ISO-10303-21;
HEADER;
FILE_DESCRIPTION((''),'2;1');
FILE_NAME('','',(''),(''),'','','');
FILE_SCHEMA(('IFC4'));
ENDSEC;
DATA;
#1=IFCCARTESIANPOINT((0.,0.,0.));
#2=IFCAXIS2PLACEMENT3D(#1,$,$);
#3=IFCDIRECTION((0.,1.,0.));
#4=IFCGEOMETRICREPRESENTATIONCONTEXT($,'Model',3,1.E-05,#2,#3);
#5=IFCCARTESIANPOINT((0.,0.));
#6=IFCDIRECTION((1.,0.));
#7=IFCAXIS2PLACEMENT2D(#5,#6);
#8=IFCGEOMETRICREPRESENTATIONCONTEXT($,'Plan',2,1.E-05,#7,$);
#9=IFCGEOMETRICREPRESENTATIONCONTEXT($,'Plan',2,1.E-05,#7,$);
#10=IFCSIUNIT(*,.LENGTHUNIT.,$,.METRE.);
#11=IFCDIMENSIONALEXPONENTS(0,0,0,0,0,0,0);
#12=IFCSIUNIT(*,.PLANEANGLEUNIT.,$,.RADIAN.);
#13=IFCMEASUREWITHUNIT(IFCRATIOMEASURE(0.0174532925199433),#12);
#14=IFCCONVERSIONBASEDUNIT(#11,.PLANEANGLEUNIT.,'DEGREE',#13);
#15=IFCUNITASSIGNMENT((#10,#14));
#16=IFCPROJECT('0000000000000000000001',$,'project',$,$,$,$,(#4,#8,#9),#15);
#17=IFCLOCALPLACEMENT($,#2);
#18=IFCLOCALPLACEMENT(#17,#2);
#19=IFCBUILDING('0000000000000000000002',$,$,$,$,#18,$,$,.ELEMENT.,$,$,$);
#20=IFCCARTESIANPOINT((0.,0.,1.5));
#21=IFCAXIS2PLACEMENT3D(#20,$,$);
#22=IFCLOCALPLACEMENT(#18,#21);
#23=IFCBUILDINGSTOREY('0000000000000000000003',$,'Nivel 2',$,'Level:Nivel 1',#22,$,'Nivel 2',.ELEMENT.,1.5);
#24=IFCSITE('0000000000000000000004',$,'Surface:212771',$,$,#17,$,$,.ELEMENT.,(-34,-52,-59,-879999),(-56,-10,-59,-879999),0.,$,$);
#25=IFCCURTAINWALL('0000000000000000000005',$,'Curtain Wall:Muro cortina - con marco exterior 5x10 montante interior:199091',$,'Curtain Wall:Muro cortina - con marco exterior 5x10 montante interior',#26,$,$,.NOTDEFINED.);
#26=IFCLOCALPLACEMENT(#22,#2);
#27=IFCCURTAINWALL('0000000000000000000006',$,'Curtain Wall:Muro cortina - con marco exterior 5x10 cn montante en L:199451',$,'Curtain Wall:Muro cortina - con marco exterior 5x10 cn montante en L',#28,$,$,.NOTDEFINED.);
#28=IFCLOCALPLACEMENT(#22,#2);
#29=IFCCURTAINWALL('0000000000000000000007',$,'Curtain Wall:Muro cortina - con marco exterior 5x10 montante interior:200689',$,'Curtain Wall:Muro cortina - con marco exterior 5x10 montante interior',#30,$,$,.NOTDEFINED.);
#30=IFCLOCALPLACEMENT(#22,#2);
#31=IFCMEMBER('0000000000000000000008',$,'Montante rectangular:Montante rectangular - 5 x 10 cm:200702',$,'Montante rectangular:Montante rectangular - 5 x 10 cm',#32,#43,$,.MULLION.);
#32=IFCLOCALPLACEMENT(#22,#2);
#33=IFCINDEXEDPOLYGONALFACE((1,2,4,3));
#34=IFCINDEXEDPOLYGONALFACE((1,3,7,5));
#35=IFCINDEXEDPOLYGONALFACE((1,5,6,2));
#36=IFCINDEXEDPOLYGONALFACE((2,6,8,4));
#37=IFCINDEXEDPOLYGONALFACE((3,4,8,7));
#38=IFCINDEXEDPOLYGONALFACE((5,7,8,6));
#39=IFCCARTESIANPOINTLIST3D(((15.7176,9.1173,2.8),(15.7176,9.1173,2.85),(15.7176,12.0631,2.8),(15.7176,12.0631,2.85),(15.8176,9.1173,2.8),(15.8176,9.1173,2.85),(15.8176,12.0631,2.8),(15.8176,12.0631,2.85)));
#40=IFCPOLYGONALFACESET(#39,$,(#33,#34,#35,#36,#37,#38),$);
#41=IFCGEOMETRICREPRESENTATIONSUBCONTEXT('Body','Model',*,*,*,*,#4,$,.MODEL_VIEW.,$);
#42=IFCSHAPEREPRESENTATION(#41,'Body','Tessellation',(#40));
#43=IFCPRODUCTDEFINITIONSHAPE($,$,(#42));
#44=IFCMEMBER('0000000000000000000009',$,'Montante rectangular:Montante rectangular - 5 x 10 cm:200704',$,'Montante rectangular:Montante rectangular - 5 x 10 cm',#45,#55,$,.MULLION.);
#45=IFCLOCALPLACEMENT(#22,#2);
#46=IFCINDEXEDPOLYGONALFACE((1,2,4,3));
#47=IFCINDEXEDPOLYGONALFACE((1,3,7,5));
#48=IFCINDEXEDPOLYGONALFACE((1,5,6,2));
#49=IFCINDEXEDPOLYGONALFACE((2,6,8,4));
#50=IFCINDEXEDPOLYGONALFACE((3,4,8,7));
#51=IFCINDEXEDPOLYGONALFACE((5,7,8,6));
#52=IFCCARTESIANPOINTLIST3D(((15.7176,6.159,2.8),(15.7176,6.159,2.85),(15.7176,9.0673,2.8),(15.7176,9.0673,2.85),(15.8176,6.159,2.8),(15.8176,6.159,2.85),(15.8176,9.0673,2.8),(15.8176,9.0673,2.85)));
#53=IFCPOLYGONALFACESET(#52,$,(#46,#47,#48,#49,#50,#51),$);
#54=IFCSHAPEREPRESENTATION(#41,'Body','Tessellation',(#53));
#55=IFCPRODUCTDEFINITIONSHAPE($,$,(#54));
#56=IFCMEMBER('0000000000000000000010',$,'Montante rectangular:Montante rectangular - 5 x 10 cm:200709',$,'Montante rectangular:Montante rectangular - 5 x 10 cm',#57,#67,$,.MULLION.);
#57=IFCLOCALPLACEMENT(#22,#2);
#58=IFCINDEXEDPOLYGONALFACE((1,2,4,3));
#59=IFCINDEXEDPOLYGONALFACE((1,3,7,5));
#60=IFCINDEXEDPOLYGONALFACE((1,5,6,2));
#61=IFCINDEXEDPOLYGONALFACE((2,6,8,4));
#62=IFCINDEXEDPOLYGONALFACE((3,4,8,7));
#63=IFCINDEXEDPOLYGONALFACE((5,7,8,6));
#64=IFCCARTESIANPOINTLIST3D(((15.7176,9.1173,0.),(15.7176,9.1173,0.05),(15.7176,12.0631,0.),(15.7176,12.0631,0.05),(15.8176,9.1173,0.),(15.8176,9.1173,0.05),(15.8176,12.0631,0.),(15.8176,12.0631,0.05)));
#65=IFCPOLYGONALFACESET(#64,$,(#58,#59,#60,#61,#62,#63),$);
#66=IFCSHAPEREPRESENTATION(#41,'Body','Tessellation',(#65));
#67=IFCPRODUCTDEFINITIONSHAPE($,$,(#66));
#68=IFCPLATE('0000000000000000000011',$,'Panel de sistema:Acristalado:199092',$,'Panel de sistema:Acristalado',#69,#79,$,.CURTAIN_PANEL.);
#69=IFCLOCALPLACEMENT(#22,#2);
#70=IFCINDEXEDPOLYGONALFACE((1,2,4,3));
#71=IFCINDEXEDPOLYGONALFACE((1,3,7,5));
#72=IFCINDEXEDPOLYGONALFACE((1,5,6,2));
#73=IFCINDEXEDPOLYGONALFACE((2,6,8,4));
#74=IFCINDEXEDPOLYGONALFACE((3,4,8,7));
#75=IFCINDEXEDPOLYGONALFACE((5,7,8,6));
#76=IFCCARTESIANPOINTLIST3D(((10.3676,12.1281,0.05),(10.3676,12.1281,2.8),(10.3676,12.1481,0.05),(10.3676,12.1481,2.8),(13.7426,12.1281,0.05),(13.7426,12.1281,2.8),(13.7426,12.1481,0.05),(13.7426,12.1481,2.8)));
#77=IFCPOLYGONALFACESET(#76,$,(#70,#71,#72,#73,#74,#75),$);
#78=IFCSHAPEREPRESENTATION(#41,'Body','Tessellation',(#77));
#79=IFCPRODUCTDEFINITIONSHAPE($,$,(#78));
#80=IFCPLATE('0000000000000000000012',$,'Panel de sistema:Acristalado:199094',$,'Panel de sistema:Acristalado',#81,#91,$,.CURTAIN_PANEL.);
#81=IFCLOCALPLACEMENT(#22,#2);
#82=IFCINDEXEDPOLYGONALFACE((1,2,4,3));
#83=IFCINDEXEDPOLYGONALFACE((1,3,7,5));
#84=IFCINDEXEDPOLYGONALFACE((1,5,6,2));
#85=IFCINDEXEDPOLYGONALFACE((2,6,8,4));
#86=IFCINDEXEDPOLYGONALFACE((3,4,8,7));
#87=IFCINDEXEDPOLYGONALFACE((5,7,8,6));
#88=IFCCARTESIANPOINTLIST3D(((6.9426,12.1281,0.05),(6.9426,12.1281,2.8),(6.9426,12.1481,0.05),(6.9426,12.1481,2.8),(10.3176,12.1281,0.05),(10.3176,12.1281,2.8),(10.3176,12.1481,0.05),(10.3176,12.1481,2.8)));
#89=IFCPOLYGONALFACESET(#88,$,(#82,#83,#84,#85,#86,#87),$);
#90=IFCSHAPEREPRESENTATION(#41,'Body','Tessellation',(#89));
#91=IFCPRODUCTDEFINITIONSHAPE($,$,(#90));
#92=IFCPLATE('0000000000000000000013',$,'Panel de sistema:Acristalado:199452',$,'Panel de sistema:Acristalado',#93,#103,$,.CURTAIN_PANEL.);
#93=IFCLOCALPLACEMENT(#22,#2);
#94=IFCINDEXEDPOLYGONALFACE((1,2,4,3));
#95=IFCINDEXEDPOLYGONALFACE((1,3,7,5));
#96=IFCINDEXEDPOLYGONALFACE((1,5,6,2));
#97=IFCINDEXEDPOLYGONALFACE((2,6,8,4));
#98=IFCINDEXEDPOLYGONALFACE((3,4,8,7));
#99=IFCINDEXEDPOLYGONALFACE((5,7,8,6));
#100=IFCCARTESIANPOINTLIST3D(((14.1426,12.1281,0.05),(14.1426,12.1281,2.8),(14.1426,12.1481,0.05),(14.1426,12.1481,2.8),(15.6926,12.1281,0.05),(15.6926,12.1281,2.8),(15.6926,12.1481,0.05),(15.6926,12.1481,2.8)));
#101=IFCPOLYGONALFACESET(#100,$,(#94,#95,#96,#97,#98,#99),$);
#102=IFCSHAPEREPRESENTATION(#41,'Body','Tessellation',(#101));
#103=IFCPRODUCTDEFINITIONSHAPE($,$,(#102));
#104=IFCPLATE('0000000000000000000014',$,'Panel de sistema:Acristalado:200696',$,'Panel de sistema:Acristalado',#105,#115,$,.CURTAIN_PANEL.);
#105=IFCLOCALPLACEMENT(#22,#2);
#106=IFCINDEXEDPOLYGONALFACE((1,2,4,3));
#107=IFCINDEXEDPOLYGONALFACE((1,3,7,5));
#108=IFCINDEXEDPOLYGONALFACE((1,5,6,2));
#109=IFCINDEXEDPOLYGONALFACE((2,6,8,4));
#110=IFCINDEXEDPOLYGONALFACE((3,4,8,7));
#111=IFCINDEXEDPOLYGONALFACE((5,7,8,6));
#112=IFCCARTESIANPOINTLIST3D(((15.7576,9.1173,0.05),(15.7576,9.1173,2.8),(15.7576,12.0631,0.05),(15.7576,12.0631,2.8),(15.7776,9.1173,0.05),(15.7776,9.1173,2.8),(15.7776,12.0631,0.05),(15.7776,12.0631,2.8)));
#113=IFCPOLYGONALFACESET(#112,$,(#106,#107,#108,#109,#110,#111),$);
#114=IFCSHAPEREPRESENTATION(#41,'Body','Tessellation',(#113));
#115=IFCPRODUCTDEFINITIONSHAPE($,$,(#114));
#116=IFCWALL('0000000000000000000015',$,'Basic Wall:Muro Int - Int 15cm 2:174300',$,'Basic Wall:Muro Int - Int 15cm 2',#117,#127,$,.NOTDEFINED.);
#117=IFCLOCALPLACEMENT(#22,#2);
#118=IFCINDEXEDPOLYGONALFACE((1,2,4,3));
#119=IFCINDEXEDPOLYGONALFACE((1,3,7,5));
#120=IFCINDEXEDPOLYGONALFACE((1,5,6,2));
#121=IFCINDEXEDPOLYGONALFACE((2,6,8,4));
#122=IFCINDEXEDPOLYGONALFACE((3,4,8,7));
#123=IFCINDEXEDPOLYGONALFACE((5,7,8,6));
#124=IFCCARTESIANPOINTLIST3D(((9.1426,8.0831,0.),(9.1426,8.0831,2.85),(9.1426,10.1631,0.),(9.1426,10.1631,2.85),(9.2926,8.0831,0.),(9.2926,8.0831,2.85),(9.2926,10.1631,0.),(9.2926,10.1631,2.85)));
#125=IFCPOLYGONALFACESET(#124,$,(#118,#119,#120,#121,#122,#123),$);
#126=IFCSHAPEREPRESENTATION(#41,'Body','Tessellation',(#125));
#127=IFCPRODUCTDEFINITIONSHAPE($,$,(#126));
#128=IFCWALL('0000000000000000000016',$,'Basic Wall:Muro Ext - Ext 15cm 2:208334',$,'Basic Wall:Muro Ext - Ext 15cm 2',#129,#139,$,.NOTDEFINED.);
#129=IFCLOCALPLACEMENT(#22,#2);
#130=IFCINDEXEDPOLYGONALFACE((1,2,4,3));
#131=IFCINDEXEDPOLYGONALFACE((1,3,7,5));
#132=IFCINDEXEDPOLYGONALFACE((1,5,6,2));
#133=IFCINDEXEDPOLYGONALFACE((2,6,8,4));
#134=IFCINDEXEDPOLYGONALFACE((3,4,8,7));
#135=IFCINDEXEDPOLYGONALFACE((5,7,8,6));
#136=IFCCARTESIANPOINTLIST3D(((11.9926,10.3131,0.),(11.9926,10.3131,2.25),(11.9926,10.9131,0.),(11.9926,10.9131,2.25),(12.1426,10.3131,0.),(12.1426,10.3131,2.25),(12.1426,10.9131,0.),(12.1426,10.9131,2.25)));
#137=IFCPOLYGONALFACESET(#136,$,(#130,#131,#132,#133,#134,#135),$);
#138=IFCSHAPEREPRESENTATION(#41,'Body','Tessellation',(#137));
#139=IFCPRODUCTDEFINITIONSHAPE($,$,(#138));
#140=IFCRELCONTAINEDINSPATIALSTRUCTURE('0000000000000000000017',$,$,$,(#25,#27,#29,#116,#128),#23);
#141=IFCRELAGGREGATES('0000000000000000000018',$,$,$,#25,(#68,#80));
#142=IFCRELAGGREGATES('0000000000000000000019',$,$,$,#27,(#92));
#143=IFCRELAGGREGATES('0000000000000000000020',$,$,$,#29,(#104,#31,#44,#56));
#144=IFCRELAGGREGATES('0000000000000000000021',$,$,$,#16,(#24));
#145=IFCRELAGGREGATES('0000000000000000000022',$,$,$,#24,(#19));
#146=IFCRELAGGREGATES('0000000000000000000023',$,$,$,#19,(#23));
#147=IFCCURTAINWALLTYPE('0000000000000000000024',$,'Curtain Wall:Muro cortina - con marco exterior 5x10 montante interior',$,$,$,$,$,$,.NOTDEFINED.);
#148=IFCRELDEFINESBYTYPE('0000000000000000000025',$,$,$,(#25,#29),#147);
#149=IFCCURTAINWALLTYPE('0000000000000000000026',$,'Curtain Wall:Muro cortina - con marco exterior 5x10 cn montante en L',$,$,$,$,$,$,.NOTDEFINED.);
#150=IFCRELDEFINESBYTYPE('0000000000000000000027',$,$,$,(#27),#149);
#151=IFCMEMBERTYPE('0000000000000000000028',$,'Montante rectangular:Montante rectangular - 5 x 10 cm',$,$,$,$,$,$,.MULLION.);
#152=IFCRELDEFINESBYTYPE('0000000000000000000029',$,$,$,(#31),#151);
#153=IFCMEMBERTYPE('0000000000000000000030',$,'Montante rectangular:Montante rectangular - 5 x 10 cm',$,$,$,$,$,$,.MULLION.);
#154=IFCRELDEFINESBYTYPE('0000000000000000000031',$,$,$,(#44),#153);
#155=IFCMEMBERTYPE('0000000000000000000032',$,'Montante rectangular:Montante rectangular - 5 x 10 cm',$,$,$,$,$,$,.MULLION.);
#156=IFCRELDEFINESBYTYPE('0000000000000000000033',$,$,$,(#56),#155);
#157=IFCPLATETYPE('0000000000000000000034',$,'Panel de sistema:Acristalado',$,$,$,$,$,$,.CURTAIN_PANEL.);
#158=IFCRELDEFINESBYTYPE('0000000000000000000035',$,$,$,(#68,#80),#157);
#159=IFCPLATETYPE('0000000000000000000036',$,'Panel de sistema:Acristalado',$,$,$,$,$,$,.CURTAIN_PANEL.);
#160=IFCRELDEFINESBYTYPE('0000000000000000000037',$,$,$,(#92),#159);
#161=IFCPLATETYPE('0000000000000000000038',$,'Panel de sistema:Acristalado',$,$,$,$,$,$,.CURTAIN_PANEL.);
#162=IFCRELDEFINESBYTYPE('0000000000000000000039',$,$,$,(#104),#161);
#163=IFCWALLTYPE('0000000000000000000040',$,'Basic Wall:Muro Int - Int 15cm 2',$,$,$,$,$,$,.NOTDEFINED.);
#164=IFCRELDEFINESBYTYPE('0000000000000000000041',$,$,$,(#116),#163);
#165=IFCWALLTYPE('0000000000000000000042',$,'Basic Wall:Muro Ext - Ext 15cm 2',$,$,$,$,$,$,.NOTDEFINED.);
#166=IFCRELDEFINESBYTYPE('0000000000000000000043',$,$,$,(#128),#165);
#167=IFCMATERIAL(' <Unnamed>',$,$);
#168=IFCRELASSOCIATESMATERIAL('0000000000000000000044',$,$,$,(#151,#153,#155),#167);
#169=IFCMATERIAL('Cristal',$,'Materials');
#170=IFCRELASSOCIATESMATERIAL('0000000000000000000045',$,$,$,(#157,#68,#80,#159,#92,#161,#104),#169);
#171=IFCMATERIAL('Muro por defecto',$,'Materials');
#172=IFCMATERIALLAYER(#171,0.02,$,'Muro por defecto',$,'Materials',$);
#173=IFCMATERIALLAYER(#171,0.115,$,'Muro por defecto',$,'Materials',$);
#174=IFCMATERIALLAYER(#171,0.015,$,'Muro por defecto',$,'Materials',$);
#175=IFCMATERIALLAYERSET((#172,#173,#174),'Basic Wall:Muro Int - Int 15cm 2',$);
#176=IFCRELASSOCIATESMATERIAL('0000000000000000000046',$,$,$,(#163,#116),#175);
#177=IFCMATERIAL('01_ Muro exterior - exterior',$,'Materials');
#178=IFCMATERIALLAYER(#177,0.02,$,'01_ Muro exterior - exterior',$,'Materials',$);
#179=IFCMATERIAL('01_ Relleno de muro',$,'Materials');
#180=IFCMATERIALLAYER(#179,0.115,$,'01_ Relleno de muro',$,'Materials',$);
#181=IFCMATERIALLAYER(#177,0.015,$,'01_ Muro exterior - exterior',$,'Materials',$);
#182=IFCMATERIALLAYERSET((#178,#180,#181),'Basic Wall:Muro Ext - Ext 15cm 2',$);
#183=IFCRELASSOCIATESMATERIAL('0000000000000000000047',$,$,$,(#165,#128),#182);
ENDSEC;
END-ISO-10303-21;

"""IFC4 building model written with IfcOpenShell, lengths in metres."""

from ifc_helpers import new_model, entity, si_unit, converted_unit, direction, frame, origin, origin_2d_with_axis, place, context, subcontext, project, spatial, indexed_curve, outline, extrude, shape, source, transform, mapped, material, layer, layer_set, type_object, type_shapes, element, aggregate, save


model = new_model("IFC4")

# Units and contexts
model_context = context("Model", 3, precision=1e-05, world=origin(), true_north=direction((0.0, 1.0, 0.0)))
plan_context_1 = context("Plan", 2, precision=1e-05, world=origin_2d_with_axis())
plan_context_2 = context("Plan", 2, precision=1e-05, world=origin_2d_with_axis())
body_context = subcontext(model_context, "Body", "Model", "MODEL_VIEW")
footprint_context = subcontext(model_context, "FootPrint", "Model", "MODEL_VIEW")
ifc_project = project(units=[si_unit("LENGTHUNIT", "METRE"), converted_unit("PLANEANGLEUNIT", "DEGREE", entity("IfcRatioMeasure", 0.0174532925199433), si_unit("PLANEANGLEUNIT", "RADIAN"), dimensions=[0, 0, 0, 0, 0, 0, 0])], contexts=[model_context, plan_context_1, plan_context_2])

# Site, building, storey
site_placement = place(None, origin())
site = spatial("IfcSite", under=ifc_project, at=site_placement, Name="Surface:212771", CompositionType="ELEMENT", RefLatitude=(-34, -52, -59, -879999), RefLongitude=(-56, -10, -59, -879999), RefElevation=0.0)
building_placement = place(site_placement, origin())
building = spatial("IfcBuilding", under=site, at=building_placement, CompositionType="ELEMENT")
storey_placement = place(building_placement, frame((0.0, 0.0, 1.5)))
storey = spatial("IfcBuildingStorey", under=building, at=storey_placement, Name="Nivel 2", ObjectType="Level:Nivel 1", LongName="Nivel 2", CompositionType="ELEMENT", Elevation=1.5)

# Curtain wall
curtain_wall_type_1 = type_object("IfcCurtainWallType", Name="Curtain Wall:Muro cortina - con marco exterior 5x10 montante interior", PredefinedType="NOTDEFINED")
curtain_wall_1_placement = place(storey_placement, frame((0.0, 0.0, -1.5)))
curtain_wall_1 = element("IfcCurtainWall", 1, at=curtain_wall_1_placement, inside=storey, type_object=curtain_wall_type_1, Name="Curtain Wall:Muro cortina - con marco exterior 5x10 montante interior:199091", ObjectType="Curtain Wall:Muro cortina - con marco exterior 5x10 montante interior", PredefinedType="NOTDEFINED")
ifc_material_1 = material(Name=" <Unnamed>")

# Curtain wall
curtain_wall_type_2 = type_object("IfcCurtainWallType", Name="Curtain Wall:Muro cortina - con marco exterior 5x10 cn montante en L", PredefinedType="NOTDEFINED")
curtain_wall_2_placement = place(storey_placement, frame((0.0, 0.0, -1.5)))
curtain_wall_2 = element("IfcCurtainWall", 2, at=curtain_wall_2_placement, inside=storey, type_object=curtain_wall_type_2, Name="Curtain Wall:Muro cortina - con marco exterior 5x10 cn montante en L:199451", ObjectType="Curtain Wall:Muro cortina - con marco exterior 5x10 cn montante en L", PredefinedType="NOTDEFINED")

# Curtain wall
curtain_wall_3_placement = place(storey_placement, frame((0.0, 0.0, -1.5)))
curtain_wall_3 = element("IfcCurtainWall", 3, at=curtain_wall_3_placement, inside=storey, type_object=curtain_wall_type_1, Name="Curtain Wall:Muro cortina - con marco exterior 5x10 montante interior:200689", ObjectType="Curtain Wall:Muro cortina - con marco exterior 5x10 montante interior", PredefinedType="NOTDEFINED")

# Members
member_type_1 = type_object("IfcMemberType", Name="Montante rectangular:Montante rectangular - 5 x 10 cm", PredefinedType="MULLION", material=ifc_material_1)
shared_shape_1 = source(origin(), body_context, "Body", "SweptSolid", [
    extrude(outline(indexed_curve([(-0.05, -0.025), (0.05, -0.025), (0.05, 0.025), (-0.05, 0.025), (-0.05, -0.025)], self_intersect=False)), frame((-0.025, 0.0, -2.9458), z_axis=(0.0, 0.0, 1.0), x_axis=(0.0, -1.0, 0.0)), (0.0, 0.0, 1.0), 2.9458),
])
type_shapes(member_type_1, [shared_shape_1])
member_1_placement = place(storey_placement, frame((15.7676, 12.0631, 2.85), z_axis=(0.0, 1.0, 0.0), x_axis=(0.0, 0.0, 1.0)))
member_1 = element("IfcMember", 4, at=member_1_placement, type_object=member_type_1, Name="Montante rectangular:Montante rectangular - 5 x 10 cm:200702", ObjectType="Montante rectangular:Montante rectangular - 5 x 10 cm", PredefinedType="MULLION", context=body_context, shape_type="MappedRepresentation", body=[
    mapped(shared_shape_1, transform((0.0, 0.0, 0.0), scale=1.0)),
])
member_type_2 = type_object("IfcMemberType", Name="Montante rectangular:Montante rectangular - 5 x 10 cm", PredefinedType="MULLION", material=ifc_material_1)
shared_shape_2 = source(origin(), body_context, "Body", "SweptSolid", [
    extrude(outline(indexed_curve([(-0.05, -0.025), (0.05, -0.025), (0.05, 0.025), (-0.05, 0.025), (-0.05, -0.025)], self_intersect=False)), frame((-0.025, 0.0, -2.9083), z_axis=(0.0, 0.0, 1.0), x_axis=(0.0, -1.0, 0.0)), (0.0, 0.0, 1.0), 2.9083),
])
type_shapes(member_type_2, [shared_shape_2])
member_2_placement = place(storey_placement, frame((15.7676, 9.0673, 2.85), z_axis=(0.0, 1.0, 0.0), x_axis=(0.0, 0.0, 1.0)))
member_2 = element("IfcMember", 5, at=member_2_placement, type_object=member_type_2, Name="Montante rectangular:Montante rectangular - 5 x 10 cm:200704", ObjectType="Montante rectangular:Montante rectangular - 5 x 10 cm", PredefinedType="MULLION", context=body_context, shape_type="MappedRepresentation", body=[
    mapped(shared_shape_2, transform((0.0, 0.0, 0.0), scale=1.0)),
])
member_type_3 = type_object("IfcMemberType", Name="Montante rectangular:Montante rectangular - 5 x 10 cm", PredefinedType="MULLION", material=ifc_material_1)
shared_shape_3 = source(origin(), body_context, "Body", "SweptSolid", [
    extrude(outline(indexed_curve([(-0.05, -0.025), (0.05, -0.025), (0.05, 0.025), (-0.05, 0.025), (-0.05, -0.025)], self_intersect=False)), frame((-0.025, 0.0, -2.9458), z_axis=(0.0, 0.0, 1.0), x_axis=(0.0, -1.0, 0.0)), (0.0, 0.0, 1.0), 2.9458),
])
type_shapes(member_type_3, [shared_shape_3])
member_3_placement = place(storey_placement, frame((15.7676, 9.1173, 0.0), z_axis=(0.0, -1.0, 0.0), x_axis=(0.0, 0.0, -1.0)))
member_3 = element("IfcMember", 6, at=member_3_placement, type_object=member_type_3, Name="Montante rectangular:Montante rectangular - 5 x 10 cm:200709", ObjectType="Montante rectangular:Montante rectangular - 5 x 10 cm", PredefinedType="MULLION", context=body_context, shape_type="MappedRepresentation", body=[
    mapped(shared_shape_3, transform((0.0, 0.0, 0.0), scale=1.0)),
])

# Plates
ifc_material_2 = material(Name="Cristal", Category="Materials")
plate_type_1 = type_object("IfcPlateType", Name="Panel de sistema:Acristalado", PredefinedType="CURTAIN_PANEL", material=ifc_material_2)
shared_shape_4 = source(origin(), body_context, "Body", "SweptSolid", [
    extrude(outline(indexed_curve([(-0.01, -1.6875), (0.01, -1.6875), (0.01, 1.6875), (-0.01, 1.6875), (-0.01, -1.6875)], self_intersect=False)), frame((0.0, 0.0, 0.0), z_axis=(0.0, 0.0, 1.0), x_axis=(0.0, 1.0, 0.0)), (0.0, 0.0, 1.0), 2.75),
])
shared_shape_5 = source(origin(), footprint_context, "FootPrint", "Curve2D", [
    entity("IfcIndexedPolyCurve", entity("IfcCartesianPointList2D", [[1.6875, -0.01], [1.6875, 0.01], [-1.6875, 0.01], [-1.6875, -0.01], [1.6875, -0.01]]), None, False),
])
type_shapes(plate_type_1, [shared_shape_4, shared_shape_5])
plate_1_placement = place(curtain_wall_1_placement, frame((12.0551, 12.1381, 1.55), z_axis=(0.0, 0.0, 1.0), x_axis=(-1.0, 0.0, 0.0)))
plate_1 = element("IfcPlate", 7, at=plate_1_placement, type_object=plate_type_1, material=ifc_material_2, Name="Panel de sistema:Acristalado:199092", ObjectType="Panel de sistema:Acristalado", PredefinedType="CURTAIN_PANEL", shapes=[
    shape(body_context, "Body", "MappedRepresentation", [mapped(shared_shape_4, transform((0.0, 0.0, 0.0), scale=1.0))]),
    shape(body_context, "Body", "MappedRepresentation", [mapped(shared_shape_5, transform((0.0, 0.0, 0.0), scale=1.0))]),
])
plate_2_placement = place(curtain_wall_1_placement, frame((8.6301, 12.1381, 1.55), z_axis=(0.0, 0.0, 1.0), x_axis=(-1.0, 0.0, 0.0)))
plate_2 = element("IfcPlate", 8, at=plate_2_placement, type_object=plate_type_1, material=ifc_material_2, Name="Panel de sistema:Acristalado:199094", ObjectType="Panel de sistema:Acristalado", PredefinedType="CURTAIN_PANEL", shapes=[
    shape(body_context, "Body", "MappedRepresentation", [mapped(shared_shape_4, transform((0.0, 0.0, 0.0), scale=1.0))]),
    shape(body_context, "Body", "MappedRepresentation", [mapped(shared_shape_5, transform((0.0, 0.0, 0.0), scale=1.0))]),
])
aggregate(curtain_wall_1, [plate_1, plate_2])
plate_type_2 = type_object("IfcPlateType", Name="Panel de sistema:Acristalado", PredefinedType="CURTAIN_PANEL", material=ifc_material_2)
shared_shape_6 = source(origin(), body_context, "Body", "SweptSolid", [
    extrude(outline(indexed_curve([(-0.01, -0.775), (0.01, -0.775), (0.01, 0.775), (-0.01, 0.775), (-0.01, -0.775)], self_intersect=False)), frame((0.0, 0.0, 0.0), z_axis=(0.0, 0.0, 1.0), x_axis=(0.0, 1.0, 0.0)), (0.0, 0.0, 1.0), 2.75),
])
shared_shape_7 = source(origin(), footprint_context, "FootPrint", "Curve2D", [
    entity("IfcIndexedPolyCurve", entity("IfcCartesianPointList2D", [[0.775, -0.01], [0.775, 0.01], [-0.775, 0.01], [-0.775, -0.01], [0.775, -0.01]]), None, False),
])
type_shapes(plate_type_2, [shared_shape_6, shared_shape_7])
plate_3_placement = place(curtain_wall_2_placement, frame((14.9176, 12.1381, 1.55)))
plate_3 = element("IfcPlate", 9, at=plate_3_placement, type_object=plate_type_2, material=ifc_material_2, Name="Panel de sistema:Acristalado:199452", ObjectType="Panel de sistema:Acristalado", PredefinedType="CURTAIN_PANEL", shapes=[
    shape(body_context, "Body", "MappedRepresentation", [mapped(shared_shape_6, transform((0.0, 0.0, 0.0), scale=1.0))]),
    shape(body_context, "Body", "MappedRepresentation", [mapped(shared_shape_7, transform((0.0, 0.0, 0.0), scale=1.0))]),
])
aggregate(curtain_wall_2, [plate_3])
plate_type_3 = type_object("IfcPlateType", Name="Panel de sistema:Acristalado", PredefinedType="CURTAIN_PANEL", material=ifc_material_2)
shared_shape_8 = source(origin(), body_context, "Body", "SweptSolid", [
    extrude(outline(indexed_curve([(-0.01, -1.4729), (0.01, -1.4729), (0.01, 1.4729), (-0.01, 1.4729), (-0.01, -1.4729)], self_intersect=False)), frame((0.0, 0.0, 0.0), z_axis=(0.0, 0.0, 1.0), x_axis=(0.0, 1.0, 0.0)), (0.0, 0.0, 1.0), 2.75),
])
shared_shape_9 = source(origin(), footprint_context, "FootPrint", "Curve2D", [
    entity("IfcIndexedPolyCurve", entity("IfcCartesianPointList2D", [[1.4729, -0.01], [1.4729, 0.01], [-1.4729, 0.01], [-1.4729, -0.01], [1.4729, -0.01]]), None, False),
])
type_shapes(plate_type_3, [shared_shape_8, shared_shape_9])
plate_4_placement = place(curtain_wall_3_placement, frame((15.7676, 10.5902, 1.55), z_axis=(0.0, 0.0, 1.0), x_axis=(0.0, 1.0, 0.0)))
plate_4 = element("IfcPlate", 10, at=plate_4_placement, type_object=plate_type_3, material=ifc_material_2, Name="Panel de sistema:Acristalado:200696", ObjectType="Panel de sistema:Acristalado", PredefinedType="CURTAIN_PANEL", shapes=[
    shape(body_context, "Body", "MappedRepresentation", [mapped(shared_shape_8, transform((0.0, 0.0, 0.0), scale=1.0))]),
    shape(body_context, "Body", "MappedRepresentation", [mapped(shared_shape_9, transform((0.0, 0.0, 0.0), scale=1.0))]),
])
aggregate(curtain_wall_3, [plate_4, member_1, member_2, member_3])

# Walls
ifc_material_3 = material(Name="Muro por defecto", Category="Materials")
ifc_layer_1 = layer(ifc_material_3, 0.02, Name="Muro por defecto", Category="Materials")
ifc_layer_2 = layer(ifc_material_3, 0.115, Name="Muro por defecto", Category="Materials")
ifc_layer_3 = layer(ifc_material_3, 0.015, Name="Muro por defecto", Category="Materials")
ifc_layer_set_1 = layer_set([ifc_layer_1, ifc_layer_2, ifc_layer_3], Name="Basic Wall:Muro Int - Int 15cm 2")
wall_type_1 = type_object("IfcWallType", Name="Basic Wall:Muro Int - Int 15cm 2", PredefinedType="NOTDEFINED", material=ifc_layer_set_1)
wall_1_placement = place(storey_placement, frame((9.2176, 10.1631, 0.0), z_axis=(0.0, 0.0, 1.0), x_axis=(0.0, -1.0, 0.0)))
element("IfcWall", 11, at=wall_1_placement, inside=storey, type_object=wall_type_1, material=ifc_layer_set_1, Name="Basic Wall:Muro Int - Int 15cm 2:174300", ObjectType="Basic Wall:Muro Int - Int 15cm 2", PredefinedType="NOTDEFINED", context=body_context, shape_type="SweptSolid", body=[
    extrude(outline(indexed_curve([(2.08, 0.075), (0.0, 0.075), (0.0, -0.075), (2.08, -0.075), (2.08, 0.075)], self_intersect=False)), origin(), (0.0, 0.0, 1.0), 2.85),
])
ifc_material_4 = material(Name="01_ Muro exterior - exterior", Category="Materials")
ifc_layer_4 = layer(ifc_material_4, 0.02, Name="01_ Muro exterior - exterior", Category="Materials")
ifc_material_5 = material(Name="01_ Relleno de muro", Category="Materials")
ifc_layer_5 = layer(ifc_material_5, 0.115, Name="01_ Relleno de muro", Category="Materials")
ifc_layer_6 = layer(ifc_material_4, 0.015, Name="01_ Muro exterior - exterior", Category="Materials")
ifc_layer_set_2 = layer_set([ifc_layer_4, ifc_layer_5, ifc_layer_6], Name="Basic Wall:Muro Ext - Ext 15cm 2")
wall_type_2 = type_object("IfcWallType", Name="Basic Wall:Muro Ext - Ext 15cm 2", PredefinedType="NOTDEFINED", material=ifc_layer_set_2)
wall_2_placement = place(storey_placement, frame((12.0676, 10.3131, 0.0), z_axis=(0.0, 0.0, 1.0), x_axis=(0.0, 1.0, 0.0)))
element("IfcWall", 12, at=wall_2_placement, inside=storey, type_object=wall_type_2, material=ifc_layer_set_2, Name="Basic Wall:Muro Ext - Ext 15cm 2:208334", ObjectType="Basic Wall:Muro Ext - Ext 15cm 2", PredefinedType="NOTDEFINED", context=body_context, shape_type="SweptSolid", body=[
    extrude(outline(indexed_curve([(0.6, 0.075), (0.0, 0.075), (0.0, -0.075), (0.6, -0.075), (0.6, 0.075)], self_intersect=False)), origin(), (0.0, 0.0, 1.0), 2.25),
])

save(model, "model.ifc")
